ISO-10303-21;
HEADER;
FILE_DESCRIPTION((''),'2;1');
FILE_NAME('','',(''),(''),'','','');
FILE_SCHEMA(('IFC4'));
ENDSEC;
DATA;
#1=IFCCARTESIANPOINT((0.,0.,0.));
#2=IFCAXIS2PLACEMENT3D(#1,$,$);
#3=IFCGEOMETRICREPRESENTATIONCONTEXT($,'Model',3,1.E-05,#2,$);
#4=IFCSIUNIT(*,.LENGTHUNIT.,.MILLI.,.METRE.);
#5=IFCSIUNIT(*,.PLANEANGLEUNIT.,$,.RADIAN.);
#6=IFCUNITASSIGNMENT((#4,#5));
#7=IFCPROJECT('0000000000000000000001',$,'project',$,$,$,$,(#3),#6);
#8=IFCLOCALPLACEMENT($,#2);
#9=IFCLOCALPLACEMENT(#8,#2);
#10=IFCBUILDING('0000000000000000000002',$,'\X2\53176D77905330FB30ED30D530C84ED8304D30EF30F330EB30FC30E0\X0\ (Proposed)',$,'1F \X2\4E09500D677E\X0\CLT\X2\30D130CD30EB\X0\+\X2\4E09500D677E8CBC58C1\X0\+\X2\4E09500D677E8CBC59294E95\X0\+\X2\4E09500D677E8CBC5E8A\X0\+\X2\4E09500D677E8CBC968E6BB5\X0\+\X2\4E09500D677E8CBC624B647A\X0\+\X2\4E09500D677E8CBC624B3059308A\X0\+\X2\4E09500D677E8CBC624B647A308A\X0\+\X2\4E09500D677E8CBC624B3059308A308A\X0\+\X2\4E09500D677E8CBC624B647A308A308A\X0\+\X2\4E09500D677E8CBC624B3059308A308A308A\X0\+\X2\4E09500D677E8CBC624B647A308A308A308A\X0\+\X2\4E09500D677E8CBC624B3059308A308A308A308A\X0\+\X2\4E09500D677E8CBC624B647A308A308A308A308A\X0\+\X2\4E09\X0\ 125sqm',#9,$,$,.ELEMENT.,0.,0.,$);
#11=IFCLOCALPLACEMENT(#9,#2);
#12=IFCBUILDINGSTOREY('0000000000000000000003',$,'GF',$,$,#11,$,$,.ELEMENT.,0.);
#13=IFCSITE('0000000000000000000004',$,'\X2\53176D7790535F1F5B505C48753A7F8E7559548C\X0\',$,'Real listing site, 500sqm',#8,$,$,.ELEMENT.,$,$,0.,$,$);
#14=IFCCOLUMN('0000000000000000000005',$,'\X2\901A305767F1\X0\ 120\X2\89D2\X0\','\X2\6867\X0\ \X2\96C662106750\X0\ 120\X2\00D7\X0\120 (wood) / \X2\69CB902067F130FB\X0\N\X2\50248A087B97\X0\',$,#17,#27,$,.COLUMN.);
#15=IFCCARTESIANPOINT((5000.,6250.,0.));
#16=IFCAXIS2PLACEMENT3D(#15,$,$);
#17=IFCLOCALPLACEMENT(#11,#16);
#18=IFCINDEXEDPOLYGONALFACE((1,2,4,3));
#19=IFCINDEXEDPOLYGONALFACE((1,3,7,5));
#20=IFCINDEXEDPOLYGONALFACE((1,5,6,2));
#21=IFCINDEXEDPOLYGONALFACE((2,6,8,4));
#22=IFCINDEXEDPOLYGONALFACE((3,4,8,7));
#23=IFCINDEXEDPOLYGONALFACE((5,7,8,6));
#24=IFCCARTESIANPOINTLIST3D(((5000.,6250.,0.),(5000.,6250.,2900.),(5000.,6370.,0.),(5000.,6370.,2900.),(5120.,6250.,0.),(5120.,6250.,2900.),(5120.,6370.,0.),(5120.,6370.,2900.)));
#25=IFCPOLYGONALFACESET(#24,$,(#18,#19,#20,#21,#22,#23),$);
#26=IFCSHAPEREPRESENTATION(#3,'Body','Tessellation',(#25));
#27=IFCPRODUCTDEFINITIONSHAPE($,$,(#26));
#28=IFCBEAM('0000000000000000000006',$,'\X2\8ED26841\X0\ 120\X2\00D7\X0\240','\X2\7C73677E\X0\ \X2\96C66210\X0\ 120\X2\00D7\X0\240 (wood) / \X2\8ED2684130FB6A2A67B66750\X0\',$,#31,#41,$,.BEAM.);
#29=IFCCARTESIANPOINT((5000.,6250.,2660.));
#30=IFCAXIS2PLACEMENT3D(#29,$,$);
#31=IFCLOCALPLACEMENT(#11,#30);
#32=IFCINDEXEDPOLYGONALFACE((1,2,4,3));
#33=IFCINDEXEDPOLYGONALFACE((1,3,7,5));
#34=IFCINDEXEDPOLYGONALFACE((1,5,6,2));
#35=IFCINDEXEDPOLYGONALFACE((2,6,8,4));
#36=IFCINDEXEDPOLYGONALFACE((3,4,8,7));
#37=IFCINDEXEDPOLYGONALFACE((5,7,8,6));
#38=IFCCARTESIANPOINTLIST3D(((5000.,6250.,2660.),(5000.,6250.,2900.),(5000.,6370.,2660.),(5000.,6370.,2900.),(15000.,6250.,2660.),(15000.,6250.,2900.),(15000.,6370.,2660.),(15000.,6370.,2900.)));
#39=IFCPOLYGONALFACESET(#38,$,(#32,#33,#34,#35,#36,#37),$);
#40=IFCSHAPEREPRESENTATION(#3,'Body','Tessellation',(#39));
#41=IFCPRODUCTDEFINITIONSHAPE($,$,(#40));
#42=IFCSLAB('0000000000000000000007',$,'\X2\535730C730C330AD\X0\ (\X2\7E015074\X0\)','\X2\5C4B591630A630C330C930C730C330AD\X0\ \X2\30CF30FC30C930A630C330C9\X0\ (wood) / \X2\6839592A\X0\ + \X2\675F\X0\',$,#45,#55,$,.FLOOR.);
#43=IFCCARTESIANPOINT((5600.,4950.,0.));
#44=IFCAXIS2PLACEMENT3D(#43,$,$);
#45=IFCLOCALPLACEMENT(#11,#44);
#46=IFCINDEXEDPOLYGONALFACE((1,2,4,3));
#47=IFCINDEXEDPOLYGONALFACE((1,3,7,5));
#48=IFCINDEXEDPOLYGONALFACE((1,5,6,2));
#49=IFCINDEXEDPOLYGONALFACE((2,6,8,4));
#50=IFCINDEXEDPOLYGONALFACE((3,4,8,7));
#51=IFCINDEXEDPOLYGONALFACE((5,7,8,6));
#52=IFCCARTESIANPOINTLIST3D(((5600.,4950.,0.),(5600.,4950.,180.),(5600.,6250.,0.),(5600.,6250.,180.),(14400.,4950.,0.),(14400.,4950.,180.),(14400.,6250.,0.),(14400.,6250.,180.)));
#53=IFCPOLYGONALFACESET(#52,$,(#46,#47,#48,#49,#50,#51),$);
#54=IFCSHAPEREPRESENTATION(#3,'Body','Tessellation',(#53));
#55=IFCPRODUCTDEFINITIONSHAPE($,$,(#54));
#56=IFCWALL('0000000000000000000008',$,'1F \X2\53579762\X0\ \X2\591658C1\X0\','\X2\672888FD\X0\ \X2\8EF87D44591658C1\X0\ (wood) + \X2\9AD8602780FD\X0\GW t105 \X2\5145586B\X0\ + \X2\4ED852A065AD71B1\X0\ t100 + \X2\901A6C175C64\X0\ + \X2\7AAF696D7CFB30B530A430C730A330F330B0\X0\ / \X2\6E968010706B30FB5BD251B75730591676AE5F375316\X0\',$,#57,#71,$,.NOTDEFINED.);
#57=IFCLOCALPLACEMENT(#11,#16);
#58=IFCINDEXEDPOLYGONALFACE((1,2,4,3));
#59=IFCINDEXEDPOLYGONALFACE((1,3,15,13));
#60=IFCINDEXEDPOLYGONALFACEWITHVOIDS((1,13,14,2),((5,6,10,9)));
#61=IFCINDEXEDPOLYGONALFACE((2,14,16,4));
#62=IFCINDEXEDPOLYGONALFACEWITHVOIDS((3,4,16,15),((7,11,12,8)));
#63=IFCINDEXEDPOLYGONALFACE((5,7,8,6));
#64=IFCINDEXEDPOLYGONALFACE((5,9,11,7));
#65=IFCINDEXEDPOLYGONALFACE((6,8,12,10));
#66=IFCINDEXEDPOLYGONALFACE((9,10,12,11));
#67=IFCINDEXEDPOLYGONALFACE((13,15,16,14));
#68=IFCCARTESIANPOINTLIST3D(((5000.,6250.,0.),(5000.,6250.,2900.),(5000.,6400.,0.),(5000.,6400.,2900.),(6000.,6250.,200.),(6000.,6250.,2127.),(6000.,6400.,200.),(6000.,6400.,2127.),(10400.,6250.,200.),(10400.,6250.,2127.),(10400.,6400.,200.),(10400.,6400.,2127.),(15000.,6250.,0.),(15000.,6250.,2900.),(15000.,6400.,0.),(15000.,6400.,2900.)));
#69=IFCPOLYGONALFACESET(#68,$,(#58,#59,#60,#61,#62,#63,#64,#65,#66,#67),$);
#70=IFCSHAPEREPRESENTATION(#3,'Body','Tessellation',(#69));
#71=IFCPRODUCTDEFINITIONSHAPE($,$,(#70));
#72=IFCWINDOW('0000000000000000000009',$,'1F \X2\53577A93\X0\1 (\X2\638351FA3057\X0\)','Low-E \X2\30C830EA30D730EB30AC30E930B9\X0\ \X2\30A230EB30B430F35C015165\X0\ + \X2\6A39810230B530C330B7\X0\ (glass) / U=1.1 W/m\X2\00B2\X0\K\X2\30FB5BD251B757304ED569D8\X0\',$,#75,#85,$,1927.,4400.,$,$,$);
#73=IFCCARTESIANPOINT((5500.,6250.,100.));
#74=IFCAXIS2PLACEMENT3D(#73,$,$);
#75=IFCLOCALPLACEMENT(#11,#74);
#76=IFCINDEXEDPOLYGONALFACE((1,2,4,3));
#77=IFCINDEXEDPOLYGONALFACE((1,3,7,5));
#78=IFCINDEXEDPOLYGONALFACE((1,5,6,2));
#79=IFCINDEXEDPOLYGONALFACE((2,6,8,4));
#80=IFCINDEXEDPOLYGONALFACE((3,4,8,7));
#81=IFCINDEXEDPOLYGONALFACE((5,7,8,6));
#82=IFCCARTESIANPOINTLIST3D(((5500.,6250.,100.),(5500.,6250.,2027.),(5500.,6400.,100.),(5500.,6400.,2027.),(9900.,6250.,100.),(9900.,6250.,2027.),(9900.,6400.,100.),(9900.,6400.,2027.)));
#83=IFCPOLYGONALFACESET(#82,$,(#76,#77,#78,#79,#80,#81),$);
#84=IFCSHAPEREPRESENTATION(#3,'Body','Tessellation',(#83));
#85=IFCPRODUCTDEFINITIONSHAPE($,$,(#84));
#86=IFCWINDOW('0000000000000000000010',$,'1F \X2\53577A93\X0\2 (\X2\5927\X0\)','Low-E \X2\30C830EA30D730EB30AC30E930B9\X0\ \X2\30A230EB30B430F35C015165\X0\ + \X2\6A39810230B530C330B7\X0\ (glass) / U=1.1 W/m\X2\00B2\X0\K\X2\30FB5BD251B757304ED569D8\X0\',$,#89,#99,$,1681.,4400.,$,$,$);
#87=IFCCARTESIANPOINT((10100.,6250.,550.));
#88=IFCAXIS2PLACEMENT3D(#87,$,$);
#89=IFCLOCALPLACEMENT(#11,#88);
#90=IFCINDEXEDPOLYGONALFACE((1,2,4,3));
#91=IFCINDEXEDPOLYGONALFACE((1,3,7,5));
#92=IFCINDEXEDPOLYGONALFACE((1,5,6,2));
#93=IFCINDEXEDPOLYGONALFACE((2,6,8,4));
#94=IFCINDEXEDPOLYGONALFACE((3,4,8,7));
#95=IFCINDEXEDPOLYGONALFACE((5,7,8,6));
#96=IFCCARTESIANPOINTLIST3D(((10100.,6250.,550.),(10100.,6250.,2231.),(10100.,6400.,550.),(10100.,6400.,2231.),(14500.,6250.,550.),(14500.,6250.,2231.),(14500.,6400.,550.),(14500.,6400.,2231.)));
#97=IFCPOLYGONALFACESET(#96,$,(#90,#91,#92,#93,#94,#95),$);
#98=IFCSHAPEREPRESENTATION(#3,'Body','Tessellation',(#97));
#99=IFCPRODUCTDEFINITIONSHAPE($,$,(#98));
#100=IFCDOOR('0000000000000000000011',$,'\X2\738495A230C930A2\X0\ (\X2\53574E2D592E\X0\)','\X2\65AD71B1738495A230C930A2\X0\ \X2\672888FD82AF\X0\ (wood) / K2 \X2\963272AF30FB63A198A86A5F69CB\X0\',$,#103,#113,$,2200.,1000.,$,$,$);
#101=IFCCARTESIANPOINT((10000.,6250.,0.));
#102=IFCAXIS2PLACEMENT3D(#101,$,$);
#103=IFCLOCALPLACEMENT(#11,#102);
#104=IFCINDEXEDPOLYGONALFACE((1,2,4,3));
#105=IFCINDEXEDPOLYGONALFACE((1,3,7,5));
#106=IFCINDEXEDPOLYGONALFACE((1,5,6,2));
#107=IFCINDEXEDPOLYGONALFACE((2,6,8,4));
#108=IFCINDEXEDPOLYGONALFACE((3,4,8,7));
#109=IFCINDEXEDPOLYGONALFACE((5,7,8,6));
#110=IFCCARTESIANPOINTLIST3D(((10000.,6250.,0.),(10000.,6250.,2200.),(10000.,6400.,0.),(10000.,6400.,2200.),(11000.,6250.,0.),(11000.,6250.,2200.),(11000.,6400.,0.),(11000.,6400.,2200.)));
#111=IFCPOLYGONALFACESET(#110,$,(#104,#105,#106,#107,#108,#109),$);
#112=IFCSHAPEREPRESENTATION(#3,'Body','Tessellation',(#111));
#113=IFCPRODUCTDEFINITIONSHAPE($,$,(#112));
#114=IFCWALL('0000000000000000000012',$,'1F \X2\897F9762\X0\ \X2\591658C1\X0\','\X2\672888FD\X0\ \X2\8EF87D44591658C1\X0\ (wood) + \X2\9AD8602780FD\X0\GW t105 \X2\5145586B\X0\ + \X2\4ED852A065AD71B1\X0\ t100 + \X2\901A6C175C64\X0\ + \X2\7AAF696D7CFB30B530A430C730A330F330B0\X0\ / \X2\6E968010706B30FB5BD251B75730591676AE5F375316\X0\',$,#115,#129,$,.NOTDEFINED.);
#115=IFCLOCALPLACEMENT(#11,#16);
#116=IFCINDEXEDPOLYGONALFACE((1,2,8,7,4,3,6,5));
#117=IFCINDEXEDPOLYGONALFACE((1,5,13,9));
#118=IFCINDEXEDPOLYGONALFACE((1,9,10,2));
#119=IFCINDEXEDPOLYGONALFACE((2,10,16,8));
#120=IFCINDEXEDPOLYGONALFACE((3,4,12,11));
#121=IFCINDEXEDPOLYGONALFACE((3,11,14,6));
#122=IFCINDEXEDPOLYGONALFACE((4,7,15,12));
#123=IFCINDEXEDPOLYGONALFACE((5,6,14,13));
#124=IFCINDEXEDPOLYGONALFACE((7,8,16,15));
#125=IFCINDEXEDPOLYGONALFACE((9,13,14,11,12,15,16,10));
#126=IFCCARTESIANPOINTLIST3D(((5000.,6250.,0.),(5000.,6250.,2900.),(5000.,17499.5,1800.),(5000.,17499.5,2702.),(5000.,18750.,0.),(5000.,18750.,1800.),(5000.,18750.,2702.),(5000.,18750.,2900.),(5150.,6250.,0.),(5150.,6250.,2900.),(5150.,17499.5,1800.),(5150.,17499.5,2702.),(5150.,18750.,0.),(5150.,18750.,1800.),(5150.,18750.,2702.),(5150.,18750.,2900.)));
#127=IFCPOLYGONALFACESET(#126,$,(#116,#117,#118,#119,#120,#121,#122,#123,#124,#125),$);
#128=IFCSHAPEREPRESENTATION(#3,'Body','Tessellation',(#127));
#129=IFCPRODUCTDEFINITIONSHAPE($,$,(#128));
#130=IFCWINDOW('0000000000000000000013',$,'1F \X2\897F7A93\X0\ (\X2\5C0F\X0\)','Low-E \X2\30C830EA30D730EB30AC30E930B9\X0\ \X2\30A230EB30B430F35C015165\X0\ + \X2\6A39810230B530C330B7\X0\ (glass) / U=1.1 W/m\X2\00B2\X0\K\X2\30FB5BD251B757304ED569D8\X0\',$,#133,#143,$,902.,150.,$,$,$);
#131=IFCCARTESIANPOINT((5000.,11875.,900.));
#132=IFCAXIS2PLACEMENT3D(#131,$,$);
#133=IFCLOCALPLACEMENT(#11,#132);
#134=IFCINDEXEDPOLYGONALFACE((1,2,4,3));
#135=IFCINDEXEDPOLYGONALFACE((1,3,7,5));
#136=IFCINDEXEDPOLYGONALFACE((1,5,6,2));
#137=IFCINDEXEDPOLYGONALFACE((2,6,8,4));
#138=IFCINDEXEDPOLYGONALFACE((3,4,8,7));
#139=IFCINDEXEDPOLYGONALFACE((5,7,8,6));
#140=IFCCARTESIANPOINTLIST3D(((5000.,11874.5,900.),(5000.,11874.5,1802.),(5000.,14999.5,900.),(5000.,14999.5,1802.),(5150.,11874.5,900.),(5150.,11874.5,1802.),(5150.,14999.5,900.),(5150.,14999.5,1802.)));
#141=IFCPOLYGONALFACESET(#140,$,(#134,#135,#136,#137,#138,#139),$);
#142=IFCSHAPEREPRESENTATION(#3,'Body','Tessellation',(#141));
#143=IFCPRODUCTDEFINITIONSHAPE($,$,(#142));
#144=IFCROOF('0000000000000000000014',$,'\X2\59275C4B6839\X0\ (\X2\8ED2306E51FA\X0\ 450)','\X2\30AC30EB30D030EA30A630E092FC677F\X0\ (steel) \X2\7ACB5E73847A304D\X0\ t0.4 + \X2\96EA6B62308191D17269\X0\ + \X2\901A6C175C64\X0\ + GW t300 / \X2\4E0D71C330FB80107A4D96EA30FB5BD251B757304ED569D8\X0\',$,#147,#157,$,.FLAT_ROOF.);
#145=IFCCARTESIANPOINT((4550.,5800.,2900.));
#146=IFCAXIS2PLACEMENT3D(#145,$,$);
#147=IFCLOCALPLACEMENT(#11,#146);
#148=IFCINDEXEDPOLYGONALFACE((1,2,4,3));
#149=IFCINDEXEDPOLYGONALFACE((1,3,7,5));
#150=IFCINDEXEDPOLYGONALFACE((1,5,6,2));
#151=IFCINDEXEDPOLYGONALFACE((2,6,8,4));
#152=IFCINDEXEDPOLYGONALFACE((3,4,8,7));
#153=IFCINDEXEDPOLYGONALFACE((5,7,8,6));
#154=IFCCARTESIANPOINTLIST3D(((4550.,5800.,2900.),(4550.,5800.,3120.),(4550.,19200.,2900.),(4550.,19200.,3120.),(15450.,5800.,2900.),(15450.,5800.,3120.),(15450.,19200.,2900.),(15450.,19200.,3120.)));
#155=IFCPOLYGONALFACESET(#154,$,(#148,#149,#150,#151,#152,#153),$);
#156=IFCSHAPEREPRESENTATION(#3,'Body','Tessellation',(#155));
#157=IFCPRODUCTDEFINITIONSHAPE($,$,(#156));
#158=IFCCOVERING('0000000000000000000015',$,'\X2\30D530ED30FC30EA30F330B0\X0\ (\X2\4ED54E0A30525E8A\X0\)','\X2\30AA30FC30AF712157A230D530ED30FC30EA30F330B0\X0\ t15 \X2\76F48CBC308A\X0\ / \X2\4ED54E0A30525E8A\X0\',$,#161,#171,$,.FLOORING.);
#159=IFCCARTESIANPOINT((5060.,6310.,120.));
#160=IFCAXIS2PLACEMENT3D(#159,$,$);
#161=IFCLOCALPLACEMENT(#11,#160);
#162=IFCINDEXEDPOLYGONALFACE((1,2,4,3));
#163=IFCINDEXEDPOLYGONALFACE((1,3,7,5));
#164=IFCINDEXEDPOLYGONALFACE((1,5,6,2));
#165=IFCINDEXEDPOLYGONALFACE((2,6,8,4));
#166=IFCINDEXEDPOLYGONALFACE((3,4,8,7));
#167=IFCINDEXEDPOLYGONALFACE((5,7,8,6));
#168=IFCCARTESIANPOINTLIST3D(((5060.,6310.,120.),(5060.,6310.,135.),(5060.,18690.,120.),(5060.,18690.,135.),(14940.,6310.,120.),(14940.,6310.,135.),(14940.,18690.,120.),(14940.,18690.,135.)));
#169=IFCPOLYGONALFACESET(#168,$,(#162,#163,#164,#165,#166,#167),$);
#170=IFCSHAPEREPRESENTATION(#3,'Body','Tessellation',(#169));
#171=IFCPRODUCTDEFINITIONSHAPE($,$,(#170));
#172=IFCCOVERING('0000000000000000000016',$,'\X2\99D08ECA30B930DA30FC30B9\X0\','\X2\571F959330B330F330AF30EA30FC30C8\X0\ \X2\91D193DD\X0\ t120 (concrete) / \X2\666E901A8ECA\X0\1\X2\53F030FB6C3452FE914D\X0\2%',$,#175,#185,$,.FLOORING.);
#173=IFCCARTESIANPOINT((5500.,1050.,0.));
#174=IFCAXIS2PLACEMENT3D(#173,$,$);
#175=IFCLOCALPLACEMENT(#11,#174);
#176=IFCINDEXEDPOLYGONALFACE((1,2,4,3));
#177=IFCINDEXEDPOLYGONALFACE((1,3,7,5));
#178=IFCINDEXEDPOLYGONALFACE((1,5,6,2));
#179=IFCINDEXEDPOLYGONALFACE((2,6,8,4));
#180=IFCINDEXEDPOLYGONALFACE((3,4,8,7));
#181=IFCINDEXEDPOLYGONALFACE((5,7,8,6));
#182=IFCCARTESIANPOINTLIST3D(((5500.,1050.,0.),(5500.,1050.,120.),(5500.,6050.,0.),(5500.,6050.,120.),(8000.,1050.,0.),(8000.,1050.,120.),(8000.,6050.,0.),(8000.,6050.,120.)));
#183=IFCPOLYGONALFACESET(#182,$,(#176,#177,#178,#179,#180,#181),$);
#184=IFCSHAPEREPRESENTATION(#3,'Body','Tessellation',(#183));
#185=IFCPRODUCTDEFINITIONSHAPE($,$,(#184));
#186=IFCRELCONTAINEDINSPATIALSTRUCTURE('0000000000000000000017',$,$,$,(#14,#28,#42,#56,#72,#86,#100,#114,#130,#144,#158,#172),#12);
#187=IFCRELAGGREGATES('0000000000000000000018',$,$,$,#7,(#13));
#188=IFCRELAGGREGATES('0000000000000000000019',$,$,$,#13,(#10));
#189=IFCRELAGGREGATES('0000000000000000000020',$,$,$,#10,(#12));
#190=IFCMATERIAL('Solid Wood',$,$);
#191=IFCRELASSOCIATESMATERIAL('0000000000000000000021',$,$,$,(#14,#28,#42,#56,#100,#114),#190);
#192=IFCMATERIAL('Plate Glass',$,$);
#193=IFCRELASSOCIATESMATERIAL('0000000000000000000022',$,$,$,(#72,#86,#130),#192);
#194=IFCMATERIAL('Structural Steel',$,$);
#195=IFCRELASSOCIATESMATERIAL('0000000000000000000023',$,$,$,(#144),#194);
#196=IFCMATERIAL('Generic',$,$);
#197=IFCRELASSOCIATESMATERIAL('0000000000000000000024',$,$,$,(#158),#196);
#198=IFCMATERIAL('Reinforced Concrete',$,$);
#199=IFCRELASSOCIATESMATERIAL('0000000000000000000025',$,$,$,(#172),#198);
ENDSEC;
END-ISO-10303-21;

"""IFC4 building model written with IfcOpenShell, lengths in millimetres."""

from ifc_helpers import new_model, si_unit, frame, frame_2d, origin, place, context, project, spatial, rectangle, extrude, material, element, fill, save


model = new_model("IFC4")

# Units and contexts
model_context = context("Model", 3, precision=1e-05, world=origin())
ifc_project = project(units=[si_unit("LENGTHUNIT", "METRE", prefix="MILLI"), si_unit("PLANEANGLEUNIT", "RADIAN")], contexts=[model_context])

# Site, building, storey
site_placement = place(None, origin())
site = spatial("IfcSite", under=ifc_project, at=site_placement, Name="北海道弟子屈町美留和", ObjectType="Real listing site, 500sqm", CompositionType="ELEMENT", RefElevation=0.0)
building_placement = place(site_placement, origin())
building = spatial("IfcBuilding", under=site, at=building_placement, Name="北海道・ロフト付きワンルーム (Proposed)", ObjectType="1F 三倍松CLTパネル+三倍松貼壁+三倍松貼天井+三倍松貼床+三倍松貼階段+三倍松貼手摺+三倍松貼手すり+三倍松貼手摺り+三倍松貼手すりり+三倍松貼手摺りり+三倍松貼手すりりり+三倍松貼手摺りりり+三倍松貼手すりりりり+三倍松貼手摺りりりり+三 125sqm", CompositionType="ELEMENT", ElevationOfRefHeight=0.0, ElevationOfTerrain=0.0)
storey_placement = place(building_placement, origin())
storey = spatial("IfcBuildingStorey", under=building, at=storey_placement, Name="GF", CompositionType="ELEMENT", Elevation=0.0)

# Column
ifc_material_1 = material(Name="Solid Wood")
column_1_placement = place(storey_placement, frame((5000.0, 6250.0, 0.0)))
element("IfcColumn", 1, at=column_1_placement, inside=storey, material=ifc_material_1, Name="通し柱 120角", Description="桧 集成材 120×120 (wood) / 構造柱・N値計算", PredefinedType="COLUMN", context=model_context, shape_type="SweptSolid", body=[
    extrude(rectangle(XDim=120.0, YDim=120.0, at=frame_2d((60.0, 60.0))), frame((5000.0, 6250.0, 0.0)), (0.0, 0.0, 1.0), 2900.0),
])

# Beam
beam_1_placement = place(storey_placement, frame((5000.0, 6250.0, 2660.0)))
element("IfcBeam", 2, at=beam_1_placement, inside=storey, material=ifc_material_1, Name="軒桁 120×240", Description="米松 集成 120×240 (wood) / 軒桁・横架材", PredefinedType="BEAM", context=model_context, shape_type="SweptSolid", body=[
    extrude(rectangle(XDim=10000.0, YDim=120.0, at=frame_2d((5000.0, 60.0))), frame((5000.0, 6250.0, 2660.0)), (0.0, 0.0, 1.0), 240.0),
])

# Slab
ifc_material_2 = material(Name="Reinforced Concrete")
slab_1_placement = place(storey_placement, frame((5600.0, 4950.0, 0.0)))
element("IfcSlab", 3, at=slab_1_placement, inside=storey, material=ifc_material_1, Name="南デッキ (縁側)", Description="屋外ウッドデッキ ハードウッド (wood) / 根太 + 束", PredefinedType="FLOOR", context=model_context, shape_type="SweptSolid", body=[
    extrude(rectangle(XDim=8800.0, YDim=1300.0, at=frame_2d((4400.0, 650.0))), frame((5600.0, 4950.0, 0.0)), (0.0, 0.0, 1.0), 180.0),
])

# Wall, openings, windows, door
wall_1_placement = place(storey_placement, frame((5000.0, 6250.0, 0.0)))
wall_1 = element("IfcWall", 4, at=wall_1_placement, inside=storey, material=ifc_material_1, Name="1F 南面 外壁", Description="木製 軸組外壁 (wood) + 高性能GW t105 充填 + 付加断熱 t100 + 通気層 + 窯業系サイディング / 準耐火・寒冷地外皮強化", PredefinedType="NOTDEFINED", context=model_context, shape_type="SweptSolid", body=[
    extrude(rectangle(XDim=10000.0, YDim=150.0, at=frame_2d((5000.0, 75.0))), frame((5000.0, 6250.0, 0.0)), (0.0, 0.0, 1.0), 2900.0),
])
opening_1_placement = place(storey_placement, frame((5500.0, 6250.0, 100.0)))
opening_1 = element("IfcOpeningElement", 5, at=opening_1_placement, cuts=wall_1, PredefinedType="NOTDEFINED", context=model_context, shape_type="SweptSolid", body=[
    extrude(rectangle(XDim=4400.0, YDim=150.0, at=frame_2d((2200.0, 75.0))), frame((5500.0, 6250.0, 100.0)), (0.0, 0.0, 1.0), 1927.0),
])
opening_2_placement = place(storey_placement, frame((10100.0, 6250.0, 550.0)))
opening_2 = element("IfcOpeningElement", 6, at=opening_2_placement, cuts=wall_1, PredefinedType="NOTDEFINED", context=model_context, shape_type="SweptSolid", body=[
    extrude(rectangle(XDim=4400.0, YDim=150.0, at=frame_2d((2200.0, 75.0))), frame((10100.0, 6250.0, 550.0)), (0.0, 0.0, 1.0), 1681.0),
])
opening_3_placement = place(storey_placement, frame((10000.0, 6250.0, 0.0)))
opening_3 = element("IfcOpeningElement", 7, at=opening_3_placement, cuts=wall_1, PredefinedType="NOTDEFINED", context=model_context, shape_type="SweptSolid", body=[
    extrude(rectangle(XDim=1000.0, YDim=150.0, at=frame_2d((500.0, 75.0))), frame((10000.0, 6250.0, 0.0)), (0.0, 0.0, 1.0), 2200.0),
])
ifc_material_3 = material(Name="Plate Glass")
window_1_placement = place(storey_placement, frame((5500.0, 6250.0, 100.0)))
window_1 = element("IfcWindow", 8, at=window_1_placement, inside=storey, material=ifc_material_3, Name="1F 南窓1 (掃出し)", Description="Low-E トリプルガラス アルゴン封入 + 樹脂サッシ (glass) / U=1.1 W/m²K・寒冷地仕様", OverallHeight=1927.0, OverallWidth=4400.0, context=model_context, shape_type="SweptSolid", body=[
    extrude(rectangle(XDim=4400.0, YDim=150.0, at=frame_2d((2200.0, 75.0))), frame((5500.0, 6250.0, 100.0)), (0.0, 0.0, 1.0), 1927.0),
])
fill(opening_1, window_1)
window_2_placement = place(storey_placement, frame((10100.0, 6250.0, 550.0)))
window_2 = element("IfcWindow", 9, at=window_2_placement, inside=storey, material=ifc_material_3, Name="1F 南窓2 (大)", Description="Low-E トリプルガラス アルゴン封入 + 樹脂サッシ (glass) / U=1.1 W/m²K・寒冷地仕様", OverallHeight=1681.0, OverallWidth=4400.0, context=model_context, shape_type="SweptSolid", body=[
    extrude(rectangle(XDim=4400.0, YDim=150.0, at=frame_2d((2200.0, 75.0))), frame((10100.0, 6250.0, 550.0)), (0.0, 0.0, 1.0), 1681.0),
])
fill(opening_2, window_2)
door_placement = place(storey_placement, frame((10000.0, 6250.0, 0.0)))
door = element("IfcDoor", 10, at=door_placement, inside=storey, material=ifc_material_1, Name="玄関ドア (南中央)", Description="断熱玄関ドア 木製芯 (wood) / K2 防犯・採風機構", OverallHeight=2200.0, OverallWidth=1000.0, context=model_context, shape_type="SweptSolid", body=[
    extrude(rectangle(XDim=1000.0, YDim=150.0, at=frame_2d((500.0, 75.0))), frame((10000.0, 6250.0, 0.0)), (0.0, 0.0, 1.0), 2200.0),
])
fill(opening_3, door)

# Wall, opening, window
wall_2_placement = place(storey_placement, frame((5000.0, 6250.0, 0.0)))
wall_2 = element("IfcWall", 11, at=wall_2_placement, inside=storey, material=ifc_material_1, Name="1F 西面 外壁", Description="木製 軸組外壁 (wood) + 高性能GW t105 充填 + 付加断熱 t100 + 通気層 + 窯業系サイディング / 準耐火・寒冷地外皮強化", PredefinedType="NOTDEFINED", context=model_context, shape_type="SweptSolid", body=[
    extrude(rectangle(XDim=150.0, YDim=12500.0, at=frame_2d((75.0, 6250.0))), frame((5000.0, 6250.0, 0.0)), (0.0, 0.0, 1.0), 2900.0),
])
opening_4_placement = place(storey_placement, frame((5000.0, 11875.0, 900.0)))
opening_4 = element("IfcOpeningElement", 12, at=opening_4_placement, cuts=wall_2, PredefinedType="NOTDEFINED", context=model_context, shape_type="SweptSolid", body=[
    extrude(rectangle(XDim=150.0, YDim=3125.0, at=frame_2d((75.0, 1562.0))), frame((5000.0, 11875.0, 900.0)), (0.0, 0.0, 1.0), 902.0),
])
window_3_placement = place(storey_placement, frame((5000.0, 11875.0, 900.0)))
window_3 = element("IfcWindow", 13, at=window_3_placement, inside=storey, material=ifc_material_3, Name="1F 西窓 (小)", Description="Low-E トリプルガラス アルゴン封入 + 樹脂サッシ (glass) / U=1.1 W/m²K・寒冷地仕様", OverallHeight=902.0, OverallWidth=150.0, context=model_context, shape_type="SweptSolid", body=[
    extrude(rectangle(XDim=150.0, YDim=3125.0, at=frame_2d((75.0, 1562.0))), frame((5000.0, 11875.0, 900.0)), (0.0, 0.0, 1.0), 902.0),
])
fill(opening_4, window_3)

# Roof
ifc_material_4 = material(Name="Structural Steel")
roof_placement = place(storey_placement, frame((4550.0, 5800.0, 2900.0)))
element("IfcRoof", 14, at=roof_placement, inside=storey, material=ifc_material_4, Name="大屋根 (軒の出 450)", Description="ガルバリウム鋼板 (steel) 立平葺き t0.4 + 雪止め金物 + 通気層 + GW t300 / 不燃・耐積雪・寒冷地仕様", PredefinedType="FLAT_ROOF", context=model_context, shape_type="SweptSolid", body=[
    extrude(rectangle(XDim=10900.0, YDim=13400.0, at=frame_2d((5450.0, 6700.0))), frame((4550.0, 5800.0, 2900.0)), (0.0, 0.0, 1.0), 220.0),
])

# Coverings
ifc_material_5 = material(Name="Generic")
covering_1_placement = place(storey_placement, frame((5060.0, 6310.0, 120.0)))
element("IfcCovering", 15, at=covering_1_placement, inside=storey, material=ifc_material_5, Name="フローリング (仕上げ床)", Description="オーク無垢フローリング t15 直貼り / 仕上げ床", PredefinedType="FLOORING", context=model_context, shape_type="SweptSolid", body=[
    extrude(rectangle(XDim=9880.0, YDim=12380.0, at=frame_2d((4940.0, 6190.0))), frame((5060.0, 6310.0, 120.0)), (0.0, 0.0, 1.0), 15.0),
])
covering_2_placement = place(storey_placement, frame((5500.0, 1050.0, 0.0)))
element("IfcCovering", 16, at=covering_2_placement, inside=storey, material=ifc_material_2, Name="駐車スペース", Description="土間コンクリート 金鏝 t120 (concrete) / 普通車1台・水勾配2%", PredefinedType="FLOORING", context=model_context, shape_type="SweptSolid", body=[
    extrude(rectangle(XDim=2500.0, YDim=5000.0, at=frame_2d((1250.0, 2500.0))), frame((5500.0, 1050.0, 0.0)), (0.0, 0.0, 1.0), 120.0),
])

save(model, "model.ifc")
